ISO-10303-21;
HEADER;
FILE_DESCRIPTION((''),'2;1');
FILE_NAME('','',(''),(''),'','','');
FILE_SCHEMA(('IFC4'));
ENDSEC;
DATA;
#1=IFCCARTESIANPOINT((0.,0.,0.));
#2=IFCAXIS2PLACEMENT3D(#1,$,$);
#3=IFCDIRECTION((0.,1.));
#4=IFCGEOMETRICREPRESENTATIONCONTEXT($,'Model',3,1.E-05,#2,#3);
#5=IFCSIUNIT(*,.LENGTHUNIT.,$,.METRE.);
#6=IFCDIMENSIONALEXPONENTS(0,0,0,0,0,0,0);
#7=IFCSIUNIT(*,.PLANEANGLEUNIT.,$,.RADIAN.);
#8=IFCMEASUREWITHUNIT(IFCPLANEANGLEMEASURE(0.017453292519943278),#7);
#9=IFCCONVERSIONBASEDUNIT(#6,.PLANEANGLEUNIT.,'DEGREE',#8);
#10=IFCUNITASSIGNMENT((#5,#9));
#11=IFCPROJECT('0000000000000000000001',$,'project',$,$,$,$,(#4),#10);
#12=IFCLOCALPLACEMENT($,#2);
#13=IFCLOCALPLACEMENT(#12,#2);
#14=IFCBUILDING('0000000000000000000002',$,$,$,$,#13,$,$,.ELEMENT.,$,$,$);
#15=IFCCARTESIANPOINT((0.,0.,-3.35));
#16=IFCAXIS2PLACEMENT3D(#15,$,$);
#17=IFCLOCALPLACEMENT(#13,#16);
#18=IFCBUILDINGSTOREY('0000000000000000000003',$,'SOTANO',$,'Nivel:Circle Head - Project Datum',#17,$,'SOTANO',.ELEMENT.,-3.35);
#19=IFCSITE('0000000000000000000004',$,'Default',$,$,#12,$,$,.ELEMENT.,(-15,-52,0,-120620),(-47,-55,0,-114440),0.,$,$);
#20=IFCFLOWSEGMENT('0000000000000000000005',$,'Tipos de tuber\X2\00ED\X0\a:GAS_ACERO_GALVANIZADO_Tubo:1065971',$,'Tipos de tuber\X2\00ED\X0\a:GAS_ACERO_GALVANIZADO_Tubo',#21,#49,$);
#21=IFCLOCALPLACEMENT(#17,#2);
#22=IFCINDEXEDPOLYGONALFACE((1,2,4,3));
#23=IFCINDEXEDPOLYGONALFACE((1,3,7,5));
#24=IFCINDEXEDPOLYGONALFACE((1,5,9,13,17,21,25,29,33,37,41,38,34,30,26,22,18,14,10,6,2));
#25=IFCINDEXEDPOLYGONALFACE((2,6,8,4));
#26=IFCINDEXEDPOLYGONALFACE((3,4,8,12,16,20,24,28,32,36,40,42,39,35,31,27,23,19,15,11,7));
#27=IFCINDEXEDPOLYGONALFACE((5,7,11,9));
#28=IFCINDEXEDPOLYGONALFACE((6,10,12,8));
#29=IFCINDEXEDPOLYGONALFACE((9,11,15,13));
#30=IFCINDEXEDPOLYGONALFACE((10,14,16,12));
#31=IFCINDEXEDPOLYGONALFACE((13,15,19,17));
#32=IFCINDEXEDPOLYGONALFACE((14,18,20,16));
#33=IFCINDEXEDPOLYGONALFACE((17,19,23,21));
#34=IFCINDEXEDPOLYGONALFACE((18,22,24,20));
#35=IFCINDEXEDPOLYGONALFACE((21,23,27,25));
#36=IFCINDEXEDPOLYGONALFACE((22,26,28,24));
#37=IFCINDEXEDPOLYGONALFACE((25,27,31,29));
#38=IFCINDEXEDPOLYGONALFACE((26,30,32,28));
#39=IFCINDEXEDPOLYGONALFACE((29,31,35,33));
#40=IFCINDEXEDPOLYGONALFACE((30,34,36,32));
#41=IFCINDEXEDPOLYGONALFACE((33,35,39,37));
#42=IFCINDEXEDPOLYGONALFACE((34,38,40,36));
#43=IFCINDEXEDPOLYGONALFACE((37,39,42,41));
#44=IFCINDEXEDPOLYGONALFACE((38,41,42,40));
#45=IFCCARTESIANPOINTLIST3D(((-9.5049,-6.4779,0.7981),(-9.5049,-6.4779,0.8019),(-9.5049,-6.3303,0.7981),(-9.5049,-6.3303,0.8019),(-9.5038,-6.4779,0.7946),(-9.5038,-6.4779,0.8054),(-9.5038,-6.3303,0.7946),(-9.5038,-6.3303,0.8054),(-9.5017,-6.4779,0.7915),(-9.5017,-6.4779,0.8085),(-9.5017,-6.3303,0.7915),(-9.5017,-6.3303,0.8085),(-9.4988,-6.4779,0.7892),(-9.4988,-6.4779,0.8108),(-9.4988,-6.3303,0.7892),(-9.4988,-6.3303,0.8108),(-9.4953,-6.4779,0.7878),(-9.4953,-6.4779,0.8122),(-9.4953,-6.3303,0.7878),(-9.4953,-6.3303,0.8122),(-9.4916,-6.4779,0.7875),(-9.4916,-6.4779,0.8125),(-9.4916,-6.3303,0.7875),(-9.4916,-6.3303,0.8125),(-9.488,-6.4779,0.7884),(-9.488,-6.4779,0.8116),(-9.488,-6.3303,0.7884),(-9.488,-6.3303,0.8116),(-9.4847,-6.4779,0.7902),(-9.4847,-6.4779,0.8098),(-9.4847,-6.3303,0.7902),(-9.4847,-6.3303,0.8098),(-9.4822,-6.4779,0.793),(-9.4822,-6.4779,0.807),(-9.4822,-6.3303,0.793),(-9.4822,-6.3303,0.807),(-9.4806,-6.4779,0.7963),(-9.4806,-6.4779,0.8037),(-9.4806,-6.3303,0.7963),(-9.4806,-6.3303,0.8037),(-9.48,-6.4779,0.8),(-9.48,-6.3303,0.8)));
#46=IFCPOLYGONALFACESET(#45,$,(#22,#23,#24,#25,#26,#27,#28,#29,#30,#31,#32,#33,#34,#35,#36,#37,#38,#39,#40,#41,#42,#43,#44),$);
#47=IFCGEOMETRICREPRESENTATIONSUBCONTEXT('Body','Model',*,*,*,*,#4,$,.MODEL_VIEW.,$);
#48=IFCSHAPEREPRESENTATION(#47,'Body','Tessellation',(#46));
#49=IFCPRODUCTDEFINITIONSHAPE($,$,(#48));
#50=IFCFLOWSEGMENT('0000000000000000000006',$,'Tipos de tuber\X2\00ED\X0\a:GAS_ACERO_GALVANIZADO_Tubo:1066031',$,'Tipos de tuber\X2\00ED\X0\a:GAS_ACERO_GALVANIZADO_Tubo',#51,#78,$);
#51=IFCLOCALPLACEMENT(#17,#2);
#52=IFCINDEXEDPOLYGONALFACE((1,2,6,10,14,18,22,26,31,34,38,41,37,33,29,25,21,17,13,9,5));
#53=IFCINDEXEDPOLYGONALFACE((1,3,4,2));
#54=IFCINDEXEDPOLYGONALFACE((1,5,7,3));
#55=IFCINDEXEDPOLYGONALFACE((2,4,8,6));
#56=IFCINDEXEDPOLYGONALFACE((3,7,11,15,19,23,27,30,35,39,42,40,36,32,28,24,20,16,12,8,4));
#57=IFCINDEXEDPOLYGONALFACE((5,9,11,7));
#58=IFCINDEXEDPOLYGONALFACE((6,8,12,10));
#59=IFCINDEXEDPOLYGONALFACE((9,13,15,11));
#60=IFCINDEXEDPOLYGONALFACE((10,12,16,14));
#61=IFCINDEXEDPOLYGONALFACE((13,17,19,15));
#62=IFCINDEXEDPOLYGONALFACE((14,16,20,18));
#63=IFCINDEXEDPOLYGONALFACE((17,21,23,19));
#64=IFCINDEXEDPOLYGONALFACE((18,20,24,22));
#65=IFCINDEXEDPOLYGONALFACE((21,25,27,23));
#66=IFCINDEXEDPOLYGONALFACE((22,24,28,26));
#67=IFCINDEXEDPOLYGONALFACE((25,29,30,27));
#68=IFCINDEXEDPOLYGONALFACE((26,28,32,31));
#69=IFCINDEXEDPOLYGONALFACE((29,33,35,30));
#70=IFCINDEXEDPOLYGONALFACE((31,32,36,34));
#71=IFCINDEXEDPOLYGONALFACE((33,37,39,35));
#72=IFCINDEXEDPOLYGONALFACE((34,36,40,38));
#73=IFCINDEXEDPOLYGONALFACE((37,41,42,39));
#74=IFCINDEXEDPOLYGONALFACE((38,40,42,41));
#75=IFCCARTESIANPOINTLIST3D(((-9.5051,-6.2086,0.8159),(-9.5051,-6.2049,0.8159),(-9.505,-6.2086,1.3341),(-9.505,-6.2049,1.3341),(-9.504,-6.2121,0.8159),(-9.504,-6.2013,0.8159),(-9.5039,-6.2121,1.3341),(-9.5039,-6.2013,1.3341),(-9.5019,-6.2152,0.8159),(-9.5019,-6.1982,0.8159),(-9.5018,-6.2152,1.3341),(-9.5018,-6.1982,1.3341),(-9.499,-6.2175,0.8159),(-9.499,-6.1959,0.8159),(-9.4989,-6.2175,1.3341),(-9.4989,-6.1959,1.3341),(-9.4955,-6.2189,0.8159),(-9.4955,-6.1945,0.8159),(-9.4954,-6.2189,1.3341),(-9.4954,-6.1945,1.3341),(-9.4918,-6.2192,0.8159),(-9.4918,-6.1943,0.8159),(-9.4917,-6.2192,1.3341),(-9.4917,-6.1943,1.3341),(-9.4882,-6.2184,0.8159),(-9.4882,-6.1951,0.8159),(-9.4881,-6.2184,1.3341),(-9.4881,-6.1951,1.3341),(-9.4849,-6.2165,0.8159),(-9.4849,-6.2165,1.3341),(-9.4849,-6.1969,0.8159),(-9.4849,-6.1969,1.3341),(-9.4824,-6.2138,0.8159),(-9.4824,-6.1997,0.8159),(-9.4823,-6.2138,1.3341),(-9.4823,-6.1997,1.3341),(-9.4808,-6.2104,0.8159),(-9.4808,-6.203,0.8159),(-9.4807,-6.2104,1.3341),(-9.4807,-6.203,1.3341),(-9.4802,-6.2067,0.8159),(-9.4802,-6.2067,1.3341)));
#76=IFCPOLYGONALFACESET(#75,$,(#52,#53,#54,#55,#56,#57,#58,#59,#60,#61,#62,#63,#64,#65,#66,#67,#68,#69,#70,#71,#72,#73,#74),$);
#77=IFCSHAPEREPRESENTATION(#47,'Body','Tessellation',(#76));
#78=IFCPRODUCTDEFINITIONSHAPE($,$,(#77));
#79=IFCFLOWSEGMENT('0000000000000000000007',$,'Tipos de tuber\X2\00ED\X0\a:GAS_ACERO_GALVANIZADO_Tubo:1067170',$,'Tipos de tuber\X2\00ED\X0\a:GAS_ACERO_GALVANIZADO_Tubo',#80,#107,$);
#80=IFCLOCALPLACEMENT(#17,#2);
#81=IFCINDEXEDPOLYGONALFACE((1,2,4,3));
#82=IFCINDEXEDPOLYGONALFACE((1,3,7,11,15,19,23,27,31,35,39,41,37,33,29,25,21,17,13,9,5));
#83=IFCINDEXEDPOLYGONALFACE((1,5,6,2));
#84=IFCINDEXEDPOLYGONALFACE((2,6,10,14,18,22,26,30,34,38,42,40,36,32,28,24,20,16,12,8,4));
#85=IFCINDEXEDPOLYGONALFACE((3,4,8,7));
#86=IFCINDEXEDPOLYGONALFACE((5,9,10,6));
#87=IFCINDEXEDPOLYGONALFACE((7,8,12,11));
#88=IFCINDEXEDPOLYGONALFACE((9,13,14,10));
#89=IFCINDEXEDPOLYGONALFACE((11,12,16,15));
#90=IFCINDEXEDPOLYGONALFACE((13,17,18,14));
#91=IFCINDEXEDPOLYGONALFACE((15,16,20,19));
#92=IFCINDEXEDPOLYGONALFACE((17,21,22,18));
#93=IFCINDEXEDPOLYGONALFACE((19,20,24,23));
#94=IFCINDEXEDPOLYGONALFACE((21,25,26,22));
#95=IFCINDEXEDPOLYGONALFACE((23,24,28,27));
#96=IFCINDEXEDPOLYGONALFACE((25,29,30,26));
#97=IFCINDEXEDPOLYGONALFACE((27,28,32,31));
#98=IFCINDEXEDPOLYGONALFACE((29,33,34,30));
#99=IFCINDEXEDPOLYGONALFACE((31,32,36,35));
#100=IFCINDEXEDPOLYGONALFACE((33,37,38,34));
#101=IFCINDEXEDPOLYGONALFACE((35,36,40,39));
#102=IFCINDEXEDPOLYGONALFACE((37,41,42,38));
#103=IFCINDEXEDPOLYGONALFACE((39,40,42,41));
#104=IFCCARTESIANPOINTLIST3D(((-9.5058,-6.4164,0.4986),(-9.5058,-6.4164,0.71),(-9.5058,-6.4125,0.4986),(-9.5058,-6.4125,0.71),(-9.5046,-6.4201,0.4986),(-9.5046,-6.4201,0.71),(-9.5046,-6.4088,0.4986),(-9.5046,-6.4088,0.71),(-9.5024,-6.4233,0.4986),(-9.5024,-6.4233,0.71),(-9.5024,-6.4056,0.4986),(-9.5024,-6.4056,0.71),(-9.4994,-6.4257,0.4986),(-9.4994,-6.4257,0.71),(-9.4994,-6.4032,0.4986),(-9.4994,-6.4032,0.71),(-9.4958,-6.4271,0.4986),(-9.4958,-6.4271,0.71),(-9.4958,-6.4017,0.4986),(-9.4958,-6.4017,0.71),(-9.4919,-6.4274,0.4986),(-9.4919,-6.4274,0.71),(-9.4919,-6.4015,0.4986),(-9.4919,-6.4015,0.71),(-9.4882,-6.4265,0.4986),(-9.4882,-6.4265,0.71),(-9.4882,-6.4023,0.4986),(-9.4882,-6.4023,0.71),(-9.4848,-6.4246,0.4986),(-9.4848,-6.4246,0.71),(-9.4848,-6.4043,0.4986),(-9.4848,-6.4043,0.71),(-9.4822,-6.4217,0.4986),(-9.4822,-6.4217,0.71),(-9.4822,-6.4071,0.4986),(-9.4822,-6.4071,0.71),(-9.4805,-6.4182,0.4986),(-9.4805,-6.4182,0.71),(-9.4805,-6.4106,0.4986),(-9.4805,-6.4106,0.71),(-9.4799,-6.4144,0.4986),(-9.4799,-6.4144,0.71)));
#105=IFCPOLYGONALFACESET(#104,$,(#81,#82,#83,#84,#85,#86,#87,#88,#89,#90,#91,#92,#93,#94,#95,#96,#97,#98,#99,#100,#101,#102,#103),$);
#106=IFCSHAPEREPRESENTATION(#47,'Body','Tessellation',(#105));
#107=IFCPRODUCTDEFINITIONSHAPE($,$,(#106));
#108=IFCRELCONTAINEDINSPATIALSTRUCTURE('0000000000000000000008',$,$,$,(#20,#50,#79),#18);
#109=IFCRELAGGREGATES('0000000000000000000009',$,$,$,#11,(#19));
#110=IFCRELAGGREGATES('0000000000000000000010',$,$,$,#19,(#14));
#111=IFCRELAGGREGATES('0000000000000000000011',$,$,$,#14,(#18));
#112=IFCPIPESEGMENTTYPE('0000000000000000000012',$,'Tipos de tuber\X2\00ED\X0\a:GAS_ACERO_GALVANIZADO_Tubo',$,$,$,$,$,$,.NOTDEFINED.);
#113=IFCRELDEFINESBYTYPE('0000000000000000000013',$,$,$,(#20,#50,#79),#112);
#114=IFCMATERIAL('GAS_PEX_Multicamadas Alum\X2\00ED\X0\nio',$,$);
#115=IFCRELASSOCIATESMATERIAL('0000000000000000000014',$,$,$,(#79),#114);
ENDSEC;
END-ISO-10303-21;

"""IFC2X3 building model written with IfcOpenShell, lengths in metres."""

from ifc_helpers import new_model, entity, si_unit, converted_unit, direction, frame, frame_2d, origin, origin_2d_with_axis, place, context, subcontext, project, spatial, circle, extrude, material, type_object, element, save


model = new_model("IFC2X3")

# Units and contexts
model_context = context("Model", 3, precision=1e-05, world=origin(), true_north=direction((0.0, 1.0)))
body_context = subcontext(model_context, "Body", "Model", "MODEL_VIEW")
ifc_project = project(units=[si_unit("LENGTHUNIT", "METRE"), converted_unit("PLANEANGLEUNIT", "DEGREE", entity("IfcPlaneAngleMeasure", 0.017453292519943278), si_unit("PLANEANGLEUNIT", "RADIAN"), dimensions=[0, 0, 0, 0, 0, 0, 0])], contexts=[model_context])

# Site, building, storey
site_placement = place(None, origin())
site = spatial("IfcSite", under=ifc_project, at=site_placement, Name="Default", CompositionType="ELEMENT", RefLatitude=(-15, -52, 0, -120620), RefLongitude=(-47, -55, 0, -114440), RefElevation=0.0)
building_placement = place(site_placement, origin())
building = spatial("IfcBuilding", under=site, at=building_placement, CompositionType="ELEMENT")
storey_placement = place(building_placement, frame((0.0, 0.0, -3.35)))
storey = spatial("IfcBuildingStorey", under=building, at=storey_placement, Name="SOTANO", ObjectType="Nivel:Circle Head - Project Datum", LongName="SOTANO", CompositionType="ELEMENT", Elevation=-3.35)

# Flow segments
ifc_material = material(Name="GAS_PEX_Multicamadas Alumínio")
pipe_segment_type_1 = type_object("IfcPipeSegmentType", Name="Tipos de tubería:GAS_ACERO_GALVANIZADO_Tubo", PredefinedType="NOTDEFINED")
flow_segment_1_placement = place(storey_placement, origin())
element("IfcFlowSegment", 1, at=flow_segment_1_placement, inside=storey, type_object=pipe_segment_type_1, Name="Tipos de tubería:GAS_ACERO_GALVANIZADO_Tubo:1065971", ObjectType="Tipos de tubería:GAS_ACERO_GALVANIZADO_Tubo", context=body_context, shape_type="SweptSolid", body=[
    extrude(circle(Radius=0.0125, at=origin_2d_with_axis()), frame((-9.4925, -6.4779, 0.8), z_axis=(-0.000003, 1.0, 0.0), x_axis=(1.0, 0.000003, 0.0)), (0.0, 0.0, 1.0), 0.1475),
])
flow_segment_2_placement = place(storey_placement, origin())
element("IfcFlowSegment", 2, at=flow_segment_2_placement, inside=storey, type_object=pipe_segment_type_1, Name="Tipos de tubería:GAS_ACERO_GALVANIZADO_Tubo:1066031", ObjectType="Tipos de tubería:GAS_ACERO_GALVANIZADO_Tubo", context=body_context, shape_type="SweptSolid", body=[
    extrude(circle(Radius=0.0125, at=frame_2d((0.0, 0.0), x_axis=(1.0, 0.0))), frame((-9.4927, -6.2067, 0.8159), z_axis=(0.000164, 0.0, 1.0), x_axis=(1.0, 0.0, -0.000164)), (0.0, 0.0, 1.0), 0.5182),
])
flow_segment_3_placement = place(storey_placement, origin())
element("IfcFlowSegment", 3, at=flow_segment_3_placement, inside=storey, type_object=pipe_segment_type_1, material=ifc_material, Name="Tipos de tubería:GAS_ACERO_GALVANIZADO_Tubo:1067170", ObjectType="Tipos de tubería:GAS_ACERO_GALVANIZADO_Tubo", context=body_context, shape_type="SweptSolid", body=[
    extrude(circle(Radius=0.013, at=origin_2d_with_axis()), frame((-9.4929, -6.4144, 0.4986)), (0.0, 0.0, 1.0), 0.2114),
])

save(model, "model.ifc")
